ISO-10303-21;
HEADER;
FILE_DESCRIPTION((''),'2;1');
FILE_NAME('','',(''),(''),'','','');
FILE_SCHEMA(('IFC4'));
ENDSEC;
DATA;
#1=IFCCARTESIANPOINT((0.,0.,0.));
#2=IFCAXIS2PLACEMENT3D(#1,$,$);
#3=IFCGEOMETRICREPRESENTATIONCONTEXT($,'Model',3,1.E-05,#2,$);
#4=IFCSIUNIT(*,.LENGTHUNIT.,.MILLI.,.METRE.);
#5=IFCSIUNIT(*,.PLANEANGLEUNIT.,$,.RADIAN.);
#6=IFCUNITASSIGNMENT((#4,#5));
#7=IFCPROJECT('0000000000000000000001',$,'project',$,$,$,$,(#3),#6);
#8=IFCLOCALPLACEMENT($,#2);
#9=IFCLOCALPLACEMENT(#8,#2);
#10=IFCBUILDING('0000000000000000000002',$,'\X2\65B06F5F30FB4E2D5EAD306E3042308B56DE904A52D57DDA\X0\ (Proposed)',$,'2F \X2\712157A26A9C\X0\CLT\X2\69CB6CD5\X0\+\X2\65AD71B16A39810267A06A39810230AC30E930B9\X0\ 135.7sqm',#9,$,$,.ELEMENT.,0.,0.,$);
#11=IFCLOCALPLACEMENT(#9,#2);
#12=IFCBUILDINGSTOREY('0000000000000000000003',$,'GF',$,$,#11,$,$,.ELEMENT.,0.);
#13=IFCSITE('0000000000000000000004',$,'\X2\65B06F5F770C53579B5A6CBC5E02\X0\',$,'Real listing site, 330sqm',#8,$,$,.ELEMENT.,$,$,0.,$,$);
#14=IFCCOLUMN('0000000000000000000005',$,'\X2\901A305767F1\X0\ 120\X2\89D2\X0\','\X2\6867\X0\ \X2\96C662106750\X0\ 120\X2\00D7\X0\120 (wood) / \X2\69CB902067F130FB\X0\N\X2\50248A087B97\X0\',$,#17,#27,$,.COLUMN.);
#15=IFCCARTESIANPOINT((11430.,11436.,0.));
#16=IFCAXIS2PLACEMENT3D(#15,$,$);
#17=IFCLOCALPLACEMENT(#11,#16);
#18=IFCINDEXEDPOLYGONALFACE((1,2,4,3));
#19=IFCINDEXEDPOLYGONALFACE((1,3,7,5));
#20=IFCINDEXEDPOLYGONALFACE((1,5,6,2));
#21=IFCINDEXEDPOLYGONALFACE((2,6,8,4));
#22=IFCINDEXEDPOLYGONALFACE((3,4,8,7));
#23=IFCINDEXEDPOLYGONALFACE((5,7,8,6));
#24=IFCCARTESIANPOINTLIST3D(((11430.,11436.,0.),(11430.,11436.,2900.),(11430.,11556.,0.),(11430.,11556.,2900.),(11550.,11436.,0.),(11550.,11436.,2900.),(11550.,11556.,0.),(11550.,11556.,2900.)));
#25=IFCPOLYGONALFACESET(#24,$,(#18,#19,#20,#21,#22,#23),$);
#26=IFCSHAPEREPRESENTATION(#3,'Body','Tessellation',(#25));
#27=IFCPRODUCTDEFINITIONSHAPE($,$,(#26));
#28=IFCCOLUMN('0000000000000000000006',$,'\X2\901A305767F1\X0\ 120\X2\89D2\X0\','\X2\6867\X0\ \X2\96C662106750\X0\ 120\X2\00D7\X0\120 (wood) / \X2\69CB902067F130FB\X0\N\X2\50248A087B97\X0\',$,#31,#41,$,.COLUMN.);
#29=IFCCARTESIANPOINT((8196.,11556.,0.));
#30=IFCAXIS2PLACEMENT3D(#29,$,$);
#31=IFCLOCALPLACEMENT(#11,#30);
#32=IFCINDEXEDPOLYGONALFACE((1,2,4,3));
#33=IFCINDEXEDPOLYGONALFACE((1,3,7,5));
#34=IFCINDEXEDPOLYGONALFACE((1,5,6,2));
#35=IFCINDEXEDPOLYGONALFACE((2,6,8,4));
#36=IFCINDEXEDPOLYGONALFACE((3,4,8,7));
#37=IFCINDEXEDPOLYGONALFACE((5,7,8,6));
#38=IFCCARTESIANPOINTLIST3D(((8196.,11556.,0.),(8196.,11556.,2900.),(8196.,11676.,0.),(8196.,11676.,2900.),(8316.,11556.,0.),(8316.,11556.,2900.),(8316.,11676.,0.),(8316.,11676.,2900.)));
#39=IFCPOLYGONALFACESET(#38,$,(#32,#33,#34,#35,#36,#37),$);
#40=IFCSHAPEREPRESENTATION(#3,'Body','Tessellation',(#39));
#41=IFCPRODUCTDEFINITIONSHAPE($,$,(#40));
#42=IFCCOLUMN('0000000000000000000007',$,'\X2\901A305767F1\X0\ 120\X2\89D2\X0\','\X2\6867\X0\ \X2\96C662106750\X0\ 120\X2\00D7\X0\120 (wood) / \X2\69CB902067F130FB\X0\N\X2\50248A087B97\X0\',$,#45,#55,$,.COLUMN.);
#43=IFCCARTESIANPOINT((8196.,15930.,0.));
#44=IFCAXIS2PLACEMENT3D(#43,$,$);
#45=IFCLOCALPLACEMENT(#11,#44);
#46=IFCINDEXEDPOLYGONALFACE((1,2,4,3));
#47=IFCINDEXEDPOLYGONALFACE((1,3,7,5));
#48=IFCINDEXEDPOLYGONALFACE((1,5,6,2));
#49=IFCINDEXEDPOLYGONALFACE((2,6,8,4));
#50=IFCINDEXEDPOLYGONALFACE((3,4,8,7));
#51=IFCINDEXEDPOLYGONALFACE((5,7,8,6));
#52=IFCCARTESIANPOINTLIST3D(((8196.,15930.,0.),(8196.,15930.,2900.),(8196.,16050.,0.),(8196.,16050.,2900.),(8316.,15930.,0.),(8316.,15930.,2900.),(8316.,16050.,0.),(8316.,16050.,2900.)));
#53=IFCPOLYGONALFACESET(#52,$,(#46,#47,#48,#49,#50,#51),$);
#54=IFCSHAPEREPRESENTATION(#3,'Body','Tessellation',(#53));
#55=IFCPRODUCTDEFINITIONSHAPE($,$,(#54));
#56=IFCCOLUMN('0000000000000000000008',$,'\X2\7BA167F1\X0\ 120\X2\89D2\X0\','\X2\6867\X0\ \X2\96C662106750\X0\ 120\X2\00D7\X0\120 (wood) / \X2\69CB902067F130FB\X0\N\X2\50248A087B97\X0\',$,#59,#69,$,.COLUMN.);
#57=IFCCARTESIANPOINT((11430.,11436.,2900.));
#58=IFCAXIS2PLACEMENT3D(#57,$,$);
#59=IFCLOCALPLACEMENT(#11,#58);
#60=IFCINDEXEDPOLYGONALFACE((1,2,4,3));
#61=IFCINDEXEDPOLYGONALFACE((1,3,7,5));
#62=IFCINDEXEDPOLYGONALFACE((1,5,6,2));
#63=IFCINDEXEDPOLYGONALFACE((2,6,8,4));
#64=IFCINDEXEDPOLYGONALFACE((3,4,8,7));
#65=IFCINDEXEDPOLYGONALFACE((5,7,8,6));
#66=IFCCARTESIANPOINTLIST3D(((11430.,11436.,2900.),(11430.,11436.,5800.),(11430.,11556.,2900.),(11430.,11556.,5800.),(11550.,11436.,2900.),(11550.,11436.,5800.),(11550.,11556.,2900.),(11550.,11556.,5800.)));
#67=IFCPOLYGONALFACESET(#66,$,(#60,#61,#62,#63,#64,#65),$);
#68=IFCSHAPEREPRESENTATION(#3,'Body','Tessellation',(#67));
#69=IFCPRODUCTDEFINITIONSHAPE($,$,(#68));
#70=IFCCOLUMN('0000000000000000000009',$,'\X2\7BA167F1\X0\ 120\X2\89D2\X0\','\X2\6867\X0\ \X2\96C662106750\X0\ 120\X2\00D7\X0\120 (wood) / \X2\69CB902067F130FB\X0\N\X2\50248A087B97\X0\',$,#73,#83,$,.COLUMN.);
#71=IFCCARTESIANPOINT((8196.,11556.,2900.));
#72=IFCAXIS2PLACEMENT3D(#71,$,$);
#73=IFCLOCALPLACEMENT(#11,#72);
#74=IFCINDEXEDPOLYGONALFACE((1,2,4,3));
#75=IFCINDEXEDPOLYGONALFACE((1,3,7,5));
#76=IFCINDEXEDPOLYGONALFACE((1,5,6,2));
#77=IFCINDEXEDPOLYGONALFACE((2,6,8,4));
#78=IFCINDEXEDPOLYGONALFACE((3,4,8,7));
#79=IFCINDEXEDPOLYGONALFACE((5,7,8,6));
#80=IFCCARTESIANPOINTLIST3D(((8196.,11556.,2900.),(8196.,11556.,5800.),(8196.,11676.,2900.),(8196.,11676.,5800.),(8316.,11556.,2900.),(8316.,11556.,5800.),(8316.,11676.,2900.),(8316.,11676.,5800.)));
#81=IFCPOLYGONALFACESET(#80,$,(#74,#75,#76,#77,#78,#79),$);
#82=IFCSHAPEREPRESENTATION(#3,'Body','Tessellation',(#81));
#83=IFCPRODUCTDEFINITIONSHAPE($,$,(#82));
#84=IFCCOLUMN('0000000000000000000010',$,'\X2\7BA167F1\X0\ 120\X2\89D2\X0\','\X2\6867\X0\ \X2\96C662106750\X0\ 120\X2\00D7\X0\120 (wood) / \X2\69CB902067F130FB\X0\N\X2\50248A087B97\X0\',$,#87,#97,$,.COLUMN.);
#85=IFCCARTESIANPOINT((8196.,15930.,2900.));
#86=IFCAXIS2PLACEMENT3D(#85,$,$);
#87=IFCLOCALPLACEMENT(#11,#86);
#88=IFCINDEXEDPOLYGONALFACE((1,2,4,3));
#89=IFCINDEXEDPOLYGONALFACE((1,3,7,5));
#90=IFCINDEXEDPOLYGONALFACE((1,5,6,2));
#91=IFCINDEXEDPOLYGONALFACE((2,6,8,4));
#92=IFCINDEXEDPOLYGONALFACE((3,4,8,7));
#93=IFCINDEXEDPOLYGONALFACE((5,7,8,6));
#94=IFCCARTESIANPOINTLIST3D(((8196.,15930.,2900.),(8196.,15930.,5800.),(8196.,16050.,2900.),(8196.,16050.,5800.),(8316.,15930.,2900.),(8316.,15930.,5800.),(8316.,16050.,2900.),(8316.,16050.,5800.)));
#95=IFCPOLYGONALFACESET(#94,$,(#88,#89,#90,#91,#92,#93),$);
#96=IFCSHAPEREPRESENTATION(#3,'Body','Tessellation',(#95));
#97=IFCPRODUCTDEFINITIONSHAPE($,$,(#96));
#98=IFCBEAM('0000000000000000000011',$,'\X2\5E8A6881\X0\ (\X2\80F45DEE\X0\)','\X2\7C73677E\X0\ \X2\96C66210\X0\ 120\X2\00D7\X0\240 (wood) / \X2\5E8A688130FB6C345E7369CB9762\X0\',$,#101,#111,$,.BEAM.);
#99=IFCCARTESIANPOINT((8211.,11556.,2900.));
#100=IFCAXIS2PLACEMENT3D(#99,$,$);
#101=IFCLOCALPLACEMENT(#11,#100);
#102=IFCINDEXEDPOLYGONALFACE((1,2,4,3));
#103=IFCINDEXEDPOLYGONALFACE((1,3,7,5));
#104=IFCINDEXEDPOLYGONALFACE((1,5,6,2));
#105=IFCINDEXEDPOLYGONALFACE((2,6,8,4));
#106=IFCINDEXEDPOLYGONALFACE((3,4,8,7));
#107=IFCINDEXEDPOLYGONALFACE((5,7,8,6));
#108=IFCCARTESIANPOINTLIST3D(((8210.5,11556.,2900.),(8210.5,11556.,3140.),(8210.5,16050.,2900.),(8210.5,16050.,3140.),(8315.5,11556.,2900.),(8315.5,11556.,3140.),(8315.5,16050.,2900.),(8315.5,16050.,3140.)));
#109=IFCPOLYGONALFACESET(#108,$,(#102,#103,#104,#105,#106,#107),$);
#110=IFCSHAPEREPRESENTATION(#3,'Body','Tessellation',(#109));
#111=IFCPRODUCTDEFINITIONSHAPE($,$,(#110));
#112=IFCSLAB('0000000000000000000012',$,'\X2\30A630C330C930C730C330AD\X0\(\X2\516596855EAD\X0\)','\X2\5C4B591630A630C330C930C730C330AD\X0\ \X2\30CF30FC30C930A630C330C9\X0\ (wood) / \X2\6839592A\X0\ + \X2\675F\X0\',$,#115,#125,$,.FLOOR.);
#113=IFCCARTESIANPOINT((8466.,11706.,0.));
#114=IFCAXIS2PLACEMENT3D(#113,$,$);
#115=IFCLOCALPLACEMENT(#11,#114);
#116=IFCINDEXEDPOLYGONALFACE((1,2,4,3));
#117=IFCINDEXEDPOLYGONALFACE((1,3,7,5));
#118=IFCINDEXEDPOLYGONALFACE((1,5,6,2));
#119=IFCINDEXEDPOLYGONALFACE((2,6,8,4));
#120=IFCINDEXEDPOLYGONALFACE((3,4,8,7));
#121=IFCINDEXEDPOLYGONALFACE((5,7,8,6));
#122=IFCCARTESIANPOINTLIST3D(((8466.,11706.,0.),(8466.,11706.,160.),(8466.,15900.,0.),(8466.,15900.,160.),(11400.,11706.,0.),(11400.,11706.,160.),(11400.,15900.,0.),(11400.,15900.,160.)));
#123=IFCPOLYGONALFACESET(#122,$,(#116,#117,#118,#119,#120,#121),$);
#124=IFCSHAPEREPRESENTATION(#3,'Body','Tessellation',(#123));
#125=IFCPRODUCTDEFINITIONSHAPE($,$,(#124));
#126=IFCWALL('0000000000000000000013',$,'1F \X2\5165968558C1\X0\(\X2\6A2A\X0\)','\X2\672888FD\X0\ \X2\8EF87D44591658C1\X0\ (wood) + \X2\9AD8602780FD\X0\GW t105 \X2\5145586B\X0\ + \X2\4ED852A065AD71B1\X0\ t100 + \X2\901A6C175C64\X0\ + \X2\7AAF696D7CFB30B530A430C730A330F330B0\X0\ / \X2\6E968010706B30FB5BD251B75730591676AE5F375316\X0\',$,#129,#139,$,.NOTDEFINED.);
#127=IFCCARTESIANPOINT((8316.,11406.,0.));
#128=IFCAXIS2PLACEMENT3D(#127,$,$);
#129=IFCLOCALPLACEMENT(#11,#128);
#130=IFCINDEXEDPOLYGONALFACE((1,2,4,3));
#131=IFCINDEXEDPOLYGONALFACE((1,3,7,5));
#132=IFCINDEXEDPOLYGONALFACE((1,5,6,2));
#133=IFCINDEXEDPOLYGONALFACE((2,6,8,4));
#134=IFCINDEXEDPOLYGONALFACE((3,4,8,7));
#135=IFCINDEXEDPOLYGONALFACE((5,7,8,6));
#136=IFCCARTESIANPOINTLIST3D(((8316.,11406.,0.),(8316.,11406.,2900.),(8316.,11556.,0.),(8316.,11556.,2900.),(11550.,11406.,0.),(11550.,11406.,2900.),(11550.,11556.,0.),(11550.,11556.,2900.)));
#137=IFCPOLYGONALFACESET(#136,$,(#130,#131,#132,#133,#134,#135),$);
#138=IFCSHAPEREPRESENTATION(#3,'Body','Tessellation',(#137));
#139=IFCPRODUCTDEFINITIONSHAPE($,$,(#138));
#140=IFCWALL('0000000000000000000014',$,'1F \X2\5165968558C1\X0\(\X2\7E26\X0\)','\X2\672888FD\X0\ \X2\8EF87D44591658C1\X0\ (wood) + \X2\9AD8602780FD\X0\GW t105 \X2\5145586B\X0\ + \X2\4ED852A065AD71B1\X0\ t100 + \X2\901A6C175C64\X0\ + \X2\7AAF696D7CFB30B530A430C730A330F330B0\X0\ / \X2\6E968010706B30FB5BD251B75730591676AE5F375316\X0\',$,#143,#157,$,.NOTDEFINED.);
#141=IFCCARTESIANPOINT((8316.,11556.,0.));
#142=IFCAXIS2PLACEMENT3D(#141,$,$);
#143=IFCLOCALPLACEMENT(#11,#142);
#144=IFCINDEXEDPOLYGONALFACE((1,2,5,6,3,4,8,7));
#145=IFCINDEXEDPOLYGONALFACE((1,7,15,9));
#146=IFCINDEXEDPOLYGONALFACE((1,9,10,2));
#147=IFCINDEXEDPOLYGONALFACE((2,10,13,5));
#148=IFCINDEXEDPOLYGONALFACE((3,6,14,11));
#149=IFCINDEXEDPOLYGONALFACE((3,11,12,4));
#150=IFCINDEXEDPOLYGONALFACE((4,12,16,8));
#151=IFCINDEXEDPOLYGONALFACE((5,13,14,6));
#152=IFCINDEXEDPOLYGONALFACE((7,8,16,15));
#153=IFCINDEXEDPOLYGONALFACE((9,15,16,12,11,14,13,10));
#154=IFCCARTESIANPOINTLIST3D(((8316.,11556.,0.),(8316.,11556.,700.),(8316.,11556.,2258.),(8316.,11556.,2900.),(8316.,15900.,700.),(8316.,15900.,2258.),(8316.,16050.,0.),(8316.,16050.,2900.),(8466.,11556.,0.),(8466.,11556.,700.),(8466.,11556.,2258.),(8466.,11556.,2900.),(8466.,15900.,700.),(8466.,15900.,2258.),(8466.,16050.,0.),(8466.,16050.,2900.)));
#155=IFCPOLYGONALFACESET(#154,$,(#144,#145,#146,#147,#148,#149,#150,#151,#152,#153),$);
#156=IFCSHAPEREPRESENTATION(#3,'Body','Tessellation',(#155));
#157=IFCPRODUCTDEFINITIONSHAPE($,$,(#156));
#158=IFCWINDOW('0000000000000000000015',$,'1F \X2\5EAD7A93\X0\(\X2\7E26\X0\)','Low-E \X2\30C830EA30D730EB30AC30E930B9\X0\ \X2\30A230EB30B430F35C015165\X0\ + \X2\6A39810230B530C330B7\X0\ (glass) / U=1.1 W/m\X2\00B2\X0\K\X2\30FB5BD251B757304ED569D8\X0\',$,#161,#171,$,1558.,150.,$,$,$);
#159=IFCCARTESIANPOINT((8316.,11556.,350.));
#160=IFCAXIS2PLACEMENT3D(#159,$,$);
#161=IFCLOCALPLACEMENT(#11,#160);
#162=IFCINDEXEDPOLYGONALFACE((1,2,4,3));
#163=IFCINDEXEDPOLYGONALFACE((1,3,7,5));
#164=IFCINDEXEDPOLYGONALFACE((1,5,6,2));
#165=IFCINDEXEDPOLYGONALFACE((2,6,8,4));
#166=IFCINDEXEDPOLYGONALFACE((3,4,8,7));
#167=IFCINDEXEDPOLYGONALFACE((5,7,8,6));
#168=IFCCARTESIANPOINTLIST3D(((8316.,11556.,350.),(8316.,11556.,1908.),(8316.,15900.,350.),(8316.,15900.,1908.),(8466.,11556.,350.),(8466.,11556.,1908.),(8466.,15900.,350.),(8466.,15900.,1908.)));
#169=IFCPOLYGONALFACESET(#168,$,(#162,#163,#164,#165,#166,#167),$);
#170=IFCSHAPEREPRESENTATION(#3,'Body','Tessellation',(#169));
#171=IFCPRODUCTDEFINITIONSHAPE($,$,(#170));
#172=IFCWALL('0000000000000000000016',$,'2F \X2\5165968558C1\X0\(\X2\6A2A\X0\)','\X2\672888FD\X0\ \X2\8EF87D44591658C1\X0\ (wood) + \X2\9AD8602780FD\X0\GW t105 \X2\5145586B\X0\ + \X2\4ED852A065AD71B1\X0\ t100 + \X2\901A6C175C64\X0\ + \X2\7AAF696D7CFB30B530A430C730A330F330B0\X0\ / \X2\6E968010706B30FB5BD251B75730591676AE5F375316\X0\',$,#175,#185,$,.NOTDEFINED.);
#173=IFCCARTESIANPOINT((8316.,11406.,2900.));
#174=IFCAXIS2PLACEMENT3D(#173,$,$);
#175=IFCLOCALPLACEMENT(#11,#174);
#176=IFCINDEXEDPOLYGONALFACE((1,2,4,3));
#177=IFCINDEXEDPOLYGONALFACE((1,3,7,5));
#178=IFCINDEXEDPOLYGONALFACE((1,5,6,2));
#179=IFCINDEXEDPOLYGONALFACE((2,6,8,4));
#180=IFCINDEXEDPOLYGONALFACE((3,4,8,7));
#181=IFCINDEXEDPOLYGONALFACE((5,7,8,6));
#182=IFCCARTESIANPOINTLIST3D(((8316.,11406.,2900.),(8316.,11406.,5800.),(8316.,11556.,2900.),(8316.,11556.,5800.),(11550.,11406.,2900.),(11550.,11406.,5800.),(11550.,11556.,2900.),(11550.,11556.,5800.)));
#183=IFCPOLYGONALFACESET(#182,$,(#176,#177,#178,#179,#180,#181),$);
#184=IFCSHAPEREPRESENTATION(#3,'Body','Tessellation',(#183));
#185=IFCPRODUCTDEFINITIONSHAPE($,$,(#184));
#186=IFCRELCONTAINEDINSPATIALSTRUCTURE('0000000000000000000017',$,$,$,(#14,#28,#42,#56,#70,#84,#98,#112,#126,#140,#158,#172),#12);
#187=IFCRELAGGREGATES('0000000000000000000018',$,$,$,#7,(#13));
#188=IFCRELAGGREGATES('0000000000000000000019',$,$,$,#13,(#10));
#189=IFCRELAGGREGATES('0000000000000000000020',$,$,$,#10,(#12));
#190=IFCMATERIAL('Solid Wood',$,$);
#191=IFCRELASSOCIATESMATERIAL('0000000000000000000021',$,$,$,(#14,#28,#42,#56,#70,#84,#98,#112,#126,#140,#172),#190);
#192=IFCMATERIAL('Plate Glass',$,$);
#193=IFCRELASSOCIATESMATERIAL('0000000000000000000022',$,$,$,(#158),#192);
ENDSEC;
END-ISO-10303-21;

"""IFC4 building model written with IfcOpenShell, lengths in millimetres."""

from ifc_helpers import new_model, si_unit, frame, frame_2d, origin, place, context, project, spatial, rectangle, extrude, material, element, fill, save


model = new_model("IFC4")

# Units and contexts
model_context = context("Model", 3, precision=1e-05, world=origin())
ifc_project = project(units=[si_unit("LENGTHUNIT", "METRE", prefix="MILLI"), si_unit("PLANEANGLEUNIT", "RADIAN")], contexts=[model_context])

# Site, building, storey
site_placement = place(None, origin())
site = spatial("IfcSite", under=ifc_project, at=site_placement, Name="新潟県南魚沼市", ObjectType="Real listing site, 330sqm", CompositionType="ELEMENT", RefElevation=0.0)
building_placement = place(site_placement, origin())
building = spatial("IfcBuilding", under=site, at=building_placement, Name="新潟・中庭のある回遊動線 (Proposed)", ObjectType="2F 無垢檜CLT構法+断熱樹脂枠樹脂ガラス 135.7sqm", CompositionType="ELEMENT", ElevationOfRefHeight=0.0, ElevationOfTerrain=0.0)
storey_placement = place(building_placement, origin())
storey = spatial("IfcBuildingStorey", under=building, at=storey_placement, Name="GF", CompositionType="ELEMENT", Elevation=0.0)

# Columns
ifc_material_1 = material(Name="Solid Wood")
column_1_placement = place(storey_placement, frame((11430.0, 11436.0, 0.0)))
element("IfcColumn", 1, at=column_1_placement, inside=storey, material=ifc_material_1, Name="通し柱 120角", Description="桧 集成材 120×120 (wood) / 構造柱・N値計算", PredefinedType="COLUMN", context=model_context, shape_type="SweptSolid", body=[
    extrude(rectangle(XDim=120.0, YDim=120.0, at=frame_2d((60.0, 60.0))), frame((11430.0, 11436.0, 0.0)), (0.0, 0.0, 1.0), 2900.0),
])
column_2_placement = place(storey_placement, frame((8196.0, 11556.0, 0.0)))
element("IfcColumn", 2, at=column_2_placement, inside=storey, material=ifc_material_1, Name="通し柱 120角", Description="桧 集成材 120×120 (wood) / 構造柱・N値計算", PredefinedType="COLUMN", context=model_context, shape_type="SweptSolid", body=[
    extrude(rectangle(XDim=120.0, YDim=120.0, at=frame_2d((60.0, 60.0))), frame((8196.0, 11556.0, 0.0)), (0.0, 0.0, 1.0), 2900.0),
])
column_3_placement = place(storey_placement, frame((8196.0, 15930.0, 0.0)))
element("IfcColumn", 3, at=column_3_placement, inside=storey, material=ifc_material_1, Name="通し柱 120角", Description="桧 集成材 120×120 (wood) / 構造柱・N値計算", PredefinedType="COLUMN", context=model_context, shape_type="SweptSolid", body=[
    extrude(rectangle(XDim=120.0, YDim=120.0, at=frame_2d((60.0, 60.0))), frame((8196.0, 15930.0, 0.0)), (0.0, 0.0, 1.0), 2900.0),
])
column_4_placement = place(storey_placement, frame((11430.0, 11436.0, 2900.0)))
element("IfcColumn", 4, at=column_4_placement, inside=storey, material=ifc_material_1, Name="管柱 120角", Description="桧 集成材 120×120 (wood) / 構造柱・N値計算", PredefinedType="COLUMN", context=model_context, shape_type="SweptSolid", body=[
    extrude(rectangle(XDim=120.0, YDim=120.0, at=frame_2d((60.0, 60.0))), frame((11430.0, 11436.0, 2900.0)), (0.0, 0.0, 1.0), 2900.0),
])
column_5_placement = place(storey_placement, frame((8196.0, 11556.0, 2900.0)))
element("IfcColumn", 5, at=column_5_placement, inside=storey, material=ifc_material_1, Name="管柱 120角", Description="桧 集成材 120×120 (wood) / 構造柱・N値計算", PredefinedType="COLUMN", context=model_context, shape_type="SweptSolid", body=[
    extrude(rectangle(XDim=120.0, YDim=120.0, at=frame_2d((60.0, 60.0))), frame((8196.0, 11556.0, 2900.0)), (0.0, 0.0, 1.0), 2900.0),
])
column_6_placement = place(storey_placement, frame((8196.0, 15930.0, 2900.0)))
element("IfcColumn", 6, at=column_6_placement, inside=storey, material=ifc_material_1, Name="管柱 120角", Description="桧 集成材 120×120 (wood) / 構造柱・N値計算", PredefinedType="COLUMN", context=model_context, shape_type="SweptSolid", body=[
    extrude(rectangle(XDim=120.0, YDim=120.0, at=frame_2d((60.0, 60.0))), frame((8196.0, 15930.0, 2900.0)), (0.0, 0.0, 1.0), 2900.0),
])

# Beam
beam_1_placement = place(storey_placement, frame((8211.0, 11556.0, 2900.0)))
element("IfcBeam", 7, at=beam_1_placement, inside=storey, material=ifc_material_1, Name="床梁 (胴差)", Description="米松 集成 120×240 (wood) / 床梁・水平構面", PredefinedType="BEAM", context=model_context, shape_type="SweptSolid", body=[
    extrude(rectangle(XDim=105.0, YDim=4494.0, at=frame_2d((52.0, 2247.0))), frame((8211.0, 11556.0, 2900.0)), (0.0, 0.0, 1.0), 240.0),
])

# Slab
slab_placement = place(storey_placement, frame((8466.0, 11706.0, 0.0)))
element("IfcSlab", 8, at=slab_placement, inside=storey, material=ifc_material_1, Name="ウッドデッキ(入隅庭)", Description="屋外ウッドデッキ ハードウッド (wood) / 根太 + 束", PredefinedType="FLOOR", context=model_context, shape_type="SweptSolid", body=[
    extrude(rectangle(XDim=2934.0, YDim=4194.0, at=frame_2d((1467.0, 2097.0))), frame((8466.0, 11706.0, 0.0)), (0.0, 0.0, 1.0), 160.0),
])

# Wall
wall_1_placement = place(storey_placement, frame((8316.0, 11406.0, 0.0)))
element("IfcWall", 9, at=wall_1_placement, inside=storey, material=ifc_material_1, Name="1F 入隅壁(横)", Description="木製 軸組外壁 (wood) + 高性能GW t105 充填 + 付加断熱 t100 + 通気層 + 窯業系サイディング / 準耐火・寒冷地外皮強化", PredefinedType="NOTDEFINED", context=model_context, shape_type="SweptSolid", body=[
    extrude(rectangle(XDim=3234.0, YDim=150.0, at=frame_2d((1617.0, 75.0))), frame((8316.0, 11406.0, 0.0)), (0.0, 0.0, 1.0), 2900.0),
])

# Wall, opening, window
wall_2_placement = place(storey_placement, frame((8316.0, 11556.0, 0.0)))
wall_2 = element("IfcWall", 10, at=wall_2_placement, inside=storey, material=ifc_material_1, Name="1F 入隅壁(縦)", Description="木製 軸組外壁 (wood) + 高性能GW t105 充填 + 付加断熱 t100 + 通気層 + 窯業系サイディング / 準耐火・寒冷地外皮強化", PredefinedType="NOTDEFINED", context=model_context, shape_type="SweptSolid", body=[
    extrude(rectangle(XDim=150.0, YDim=4494.0, at=frame_2d((75.0, 2247.0))), frame((8316.0, 11556.0, 0.0)), (0.0, 0.0, 1.0), 2900.0),
])
opening_1_placement = place(storey_placement, frame((8316.0, 11556.0, 350.0)))
opening_1 = element("IfcOpeningElement", 11, at=opening_1_placement, cuts=wall_2, PredefinedType="NOTDEFINED", context=model_context, shape_type="SweptSolid", body=[
    extrude(rectangle(XDim=150.0, YDim=4344.0, at=frame_2d((75.0, 2172.0))), frame((8316.0, 11556.0, 350.0)), (0.0, 0.0, 1.0), 1558.0),
])
ifc_material_2 = material(Name="Plate Glass")
window_1_placement = place(storey_placement, frame((8316.0, 11556.0, 350.0)))
window_1 = element("IfcWindow", 12, at=window_1_placement, inside=storey, material=ifc_material_2, Name="1F 庭窓(縦)", Description="Low-E トリプルガラス アルゴン封入 + 樹脂サッシ (glass) / U=1.1 W/m²K・寒冷地仕様", OverallHeight=1558.0, OverallWidth=150.0, context=model_context, shape_type="SweptSolid", body=[
    extrude(rectangle(XDim=150.0, YDim=4344.0, at=frame_2d((75.0, 2172.0))), frame((8316.0, 11556.0, 350.0)), (0.0, 0.0, 1.0), 1558.0),
])
fill(opening_1, window_1)

# Wall
wall_3_placement = place(storey_placement, frame((8316.0, 11406.0, 2900.0)))
element("IfcWall", 13, at=wall_3_placement, inside=storey, material=ifc_material_1, Name="2F 入隅壁(横)", Description="木製 軸組外壁 (wood) + 高性能GW t105 充填 + 付加断熱 t100 + 通気層 + 窯業系サイディング / 準耐火・寒冷地外皮強化", PredefinedType="NOTDEFINED", context=model_context, shape_type="SweptSolid", body=[
    extrude(rectangle(XDim=3234.0, YDim=150.0, at=frame_2d((1617.0, 75.0))), frame((8316.0, 11406.0, 2900.0)), (0.0, 0.0, 1.0), 2900.0),
])

save(model, "model.ifc")
